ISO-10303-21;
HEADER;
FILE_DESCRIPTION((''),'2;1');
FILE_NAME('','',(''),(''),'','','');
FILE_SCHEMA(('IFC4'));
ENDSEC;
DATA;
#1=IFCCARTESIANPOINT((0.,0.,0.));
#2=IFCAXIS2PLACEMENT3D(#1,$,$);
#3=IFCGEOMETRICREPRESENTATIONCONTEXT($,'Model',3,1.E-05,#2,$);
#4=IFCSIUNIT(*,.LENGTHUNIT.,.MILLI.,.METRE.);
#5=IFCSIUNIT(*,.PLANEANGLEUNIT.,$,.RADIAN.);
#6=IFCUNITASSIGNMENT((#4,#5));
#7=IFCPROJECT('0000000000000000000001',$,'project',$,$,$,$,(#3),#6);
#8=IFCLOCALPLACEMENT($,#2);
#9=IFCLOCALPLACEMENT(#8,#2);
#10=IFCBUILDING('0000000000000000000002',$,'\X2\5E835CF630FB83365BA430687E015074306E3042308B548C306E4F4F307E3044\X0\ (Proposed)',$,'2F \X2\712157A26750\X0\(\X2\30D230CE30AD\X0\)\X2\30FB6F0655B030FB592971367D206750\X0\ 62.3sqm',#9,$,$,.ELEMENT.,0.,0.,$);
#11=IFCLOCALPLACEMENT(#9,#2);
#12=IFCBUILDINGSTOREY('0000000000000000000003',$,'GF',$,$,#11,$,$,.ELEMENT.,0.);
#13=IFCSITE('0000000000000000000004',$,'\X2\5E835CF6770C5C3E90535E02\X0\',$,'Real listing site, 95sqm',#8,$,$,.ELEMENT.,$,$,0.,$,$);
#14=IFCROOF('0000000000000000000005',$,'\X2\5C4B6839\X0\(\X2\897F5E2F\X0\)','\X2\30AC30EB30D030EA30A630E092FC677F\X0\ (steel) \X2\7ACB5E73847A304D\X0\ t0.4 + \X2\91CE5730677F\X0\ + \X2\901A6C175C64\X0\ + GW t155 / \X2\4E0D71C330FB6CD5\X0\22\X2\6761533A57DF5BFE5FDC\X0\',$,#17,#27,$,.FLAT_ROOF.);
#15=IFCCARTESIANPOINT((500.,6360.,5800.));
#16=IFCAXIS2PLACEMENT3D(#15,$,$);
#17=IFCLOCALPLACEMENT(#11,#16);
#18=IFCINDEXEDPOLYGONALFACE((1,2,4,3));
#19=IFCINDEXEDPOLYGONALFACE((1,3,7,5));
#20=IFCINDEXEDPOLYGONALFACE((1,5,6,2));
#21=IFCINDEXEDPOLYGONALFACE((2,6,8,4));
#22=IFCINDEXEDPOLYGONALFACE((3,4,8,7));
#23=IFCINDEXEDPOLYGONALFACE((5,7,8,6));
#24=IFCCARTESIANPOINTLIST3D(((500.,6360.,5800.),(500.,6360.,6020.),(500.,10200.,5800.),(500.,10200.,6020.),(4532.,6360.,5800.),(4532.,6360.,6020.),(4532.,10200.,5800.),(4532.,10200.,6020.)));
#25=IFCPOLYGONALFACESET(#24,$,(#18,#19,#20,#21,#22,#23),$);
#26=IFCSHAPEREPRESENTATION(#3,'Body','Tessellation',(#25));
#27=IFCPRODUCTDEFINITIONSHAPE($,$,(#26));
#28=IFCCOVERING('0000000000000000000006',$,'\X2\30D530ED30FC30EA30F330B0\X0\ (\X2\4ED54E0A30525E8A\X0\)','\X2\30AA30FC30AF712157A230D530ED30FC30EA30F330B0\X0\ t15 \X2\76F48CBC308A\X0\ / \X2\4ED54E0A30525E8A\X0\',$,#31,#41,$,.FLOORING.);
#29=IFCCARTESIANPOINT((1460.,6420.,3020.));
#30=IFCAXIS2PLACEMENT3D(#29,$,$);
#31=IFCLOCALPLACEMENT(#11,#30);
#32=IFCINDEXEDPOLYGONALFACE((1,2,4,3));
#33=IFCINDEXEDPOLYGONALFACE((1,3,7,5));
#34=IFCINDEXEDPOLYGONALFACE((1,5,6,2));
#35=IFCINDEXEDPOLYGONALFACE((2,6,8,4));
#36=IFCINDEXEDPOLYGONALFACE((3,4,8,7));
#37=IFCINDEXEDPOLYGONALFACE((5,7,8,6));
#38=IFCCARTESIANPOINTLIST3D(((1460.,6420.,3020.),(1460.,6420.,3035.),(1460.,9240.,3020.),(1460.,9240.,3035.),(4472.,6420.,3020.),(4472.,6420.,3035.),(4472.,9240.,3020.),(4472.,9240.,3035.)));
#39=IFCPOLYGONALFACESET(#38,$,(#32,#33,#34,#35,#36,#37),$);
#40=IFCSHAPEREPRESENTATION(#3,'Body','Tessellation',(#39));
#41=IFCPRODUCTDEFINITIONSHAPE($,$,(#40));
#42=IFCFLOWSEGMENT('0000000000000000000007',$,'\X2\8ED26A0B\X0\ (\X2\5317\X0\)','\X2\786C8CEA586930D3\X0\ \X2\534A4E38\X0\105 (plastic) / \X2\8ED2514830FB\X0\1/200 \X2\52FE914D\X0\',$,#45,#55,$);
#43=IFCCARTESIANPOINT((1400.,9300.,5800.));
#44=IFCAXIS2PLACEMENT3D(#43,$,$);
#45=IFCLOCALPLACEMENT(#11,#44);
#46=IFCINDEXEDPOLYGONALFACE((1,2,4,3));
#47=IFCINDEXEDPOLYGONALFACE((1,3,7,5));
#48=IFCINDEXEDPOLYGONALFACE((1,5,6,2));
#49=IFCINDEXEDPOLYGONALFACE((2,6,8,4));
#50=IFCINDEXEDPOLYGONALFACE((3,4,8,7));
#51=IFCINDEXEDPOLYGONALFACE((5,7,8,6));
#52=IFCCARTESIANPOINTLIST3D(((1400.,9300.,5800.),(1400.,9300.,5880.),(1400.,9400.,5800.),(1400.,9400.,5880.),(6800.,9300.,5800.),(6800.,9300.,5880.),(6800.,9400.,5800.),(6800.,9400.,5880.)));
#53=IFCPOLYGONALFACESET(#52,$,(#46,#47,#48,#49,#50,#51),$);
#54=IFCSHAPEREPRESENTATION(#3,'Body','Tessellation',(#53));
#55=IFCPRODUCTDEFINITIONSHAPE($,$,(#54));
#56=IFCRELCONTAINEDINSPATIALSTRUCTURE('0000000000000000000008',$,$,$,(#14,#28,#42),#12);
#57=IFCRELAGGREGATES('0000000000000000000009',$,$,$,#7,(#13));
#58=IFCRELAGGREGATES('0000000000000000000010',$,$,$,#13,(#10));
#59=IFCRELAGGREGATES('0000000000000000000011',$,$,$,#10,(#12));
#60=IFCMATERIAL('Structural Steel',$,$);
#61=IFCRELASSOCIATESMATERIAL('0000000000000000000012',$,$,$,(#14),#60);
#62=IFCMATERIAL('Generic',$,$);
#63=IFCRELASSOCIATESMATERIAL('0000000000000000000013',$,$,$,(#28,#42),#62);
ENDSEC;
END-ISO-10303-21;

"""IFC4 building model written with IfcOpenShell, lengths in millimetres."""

from ifc_helpers import new_model, si_unit, frame, frame_2d, origin, place, context, project, spatial, rectangle, extrude, material, element, save


model = new_model("IFC4")

# Units and contexts
model_context = context("Model", 3, precision=1e-05, world=origin())
ifc_project = project(units=[si_unit("LENGTHUNIT", "METRE", prefix="MILLI"), si_unit("PLANEANGLEUNIT", "RADIAN")], contexts=[model_context])

# Site, building, storey
site_placement = place(None, origin())
site = spatial("IfcSite", under=ifc_project, at=site_placement, Name="広島県尾道市", ObjectType="Real listing site, 95sqm", CompositionType="ELEMENT", RefElevation=0.0)
building_placement = place(site_placement, origin())
building = spatial("IfcBuilding", under=site, at=building_placement, Name="広島・茶室と縁側のある和の住まい (Proposed)", ObjectType="2F 無垢材(ヒノキ)・漆喰・天然素材 62.3sqm", CompositionType="ELEMENT", ElevationOfRefHeight=0.0, ElevationOfTerrain=0.0)
storey_placement = place(building_placement, origin())
storey = spatial("IfcBuildingStorey", under=building, at=storey_placement, Name="GF", CompositionType="ELEMENT", Elevation=0.0)

# Roof
ifc_material_1 = material(Name="Structural Steel")
for number, where, name in (
    (1, (500.0, 6360.0, 5800.0), "屋根(西帯)"),
):
    element("IfcRoof", number, at=place(storey_placement, frame(where)), inside=storey, material=ifc_material_1, Name=name, Description="ガルバリウム鋼板 (steel) 立平葺き t0.4 + 野地板 + 通気層 + GW t155 / 不燃・法22条区域対応", PredefinedType="FLAT_ROOF", context=model_context, shape_type="SweptSolid", body=[
        extrude(rectangle(XDim=4032.0, YDim=3840.0, at=frame_2d((2016.0, 1920.0))), frame((500.0, 6360.0, 5800.0)), (0.0, 0.0, 1.0), 220.0),
    ])

# Covering
ifc_material_2 = material(Name="Generic")
covering_placement = place(storey_placement, frame((1460.0, 6420.0, 3020.0)))
element("IfcCovering", 2, at=covering_placement, inside=storey, material=ifc_material_2, Name="フローリング (仕上げ床)", Description="オーク無垢フローリング t15 直貼り / 仕上げ床", PredefinedType="FLOORING", context=model_context, shape_type="SweptSolid", body=[
    extrude(rectangle(XDim=3012.0, YDim=2820.0, at=frame_2d((1506.0, 1410.0))), frame((1460.0, 6420.0, 3020.0)), (0.0, 0.0, 1.0), 15.0),
])

# Flow segment
flow_segment_placement = place(storey_placement, frame((1400.0, 9300.0, 5800.0)))
element("IfcFlowSegment", 3, at=flow_segment_placement, inside=storey, material=ifc_material_2, Name="軒樋 (北)", Description="硬質塩ビ 半丸105 (plastic) / 軒先・1/200 勾配", context=model_context, shape_type="SweptSolid", body=[
    extrude(rectangle(XDim=5400.0, YDim=100.0, at=frame_2d((2700.0, 50.0))), frame((1400.0, 9300.0, 5800.0)), (0.0, 0.0, 1.0), 80.0),
])

save(model, "model.ifc")
